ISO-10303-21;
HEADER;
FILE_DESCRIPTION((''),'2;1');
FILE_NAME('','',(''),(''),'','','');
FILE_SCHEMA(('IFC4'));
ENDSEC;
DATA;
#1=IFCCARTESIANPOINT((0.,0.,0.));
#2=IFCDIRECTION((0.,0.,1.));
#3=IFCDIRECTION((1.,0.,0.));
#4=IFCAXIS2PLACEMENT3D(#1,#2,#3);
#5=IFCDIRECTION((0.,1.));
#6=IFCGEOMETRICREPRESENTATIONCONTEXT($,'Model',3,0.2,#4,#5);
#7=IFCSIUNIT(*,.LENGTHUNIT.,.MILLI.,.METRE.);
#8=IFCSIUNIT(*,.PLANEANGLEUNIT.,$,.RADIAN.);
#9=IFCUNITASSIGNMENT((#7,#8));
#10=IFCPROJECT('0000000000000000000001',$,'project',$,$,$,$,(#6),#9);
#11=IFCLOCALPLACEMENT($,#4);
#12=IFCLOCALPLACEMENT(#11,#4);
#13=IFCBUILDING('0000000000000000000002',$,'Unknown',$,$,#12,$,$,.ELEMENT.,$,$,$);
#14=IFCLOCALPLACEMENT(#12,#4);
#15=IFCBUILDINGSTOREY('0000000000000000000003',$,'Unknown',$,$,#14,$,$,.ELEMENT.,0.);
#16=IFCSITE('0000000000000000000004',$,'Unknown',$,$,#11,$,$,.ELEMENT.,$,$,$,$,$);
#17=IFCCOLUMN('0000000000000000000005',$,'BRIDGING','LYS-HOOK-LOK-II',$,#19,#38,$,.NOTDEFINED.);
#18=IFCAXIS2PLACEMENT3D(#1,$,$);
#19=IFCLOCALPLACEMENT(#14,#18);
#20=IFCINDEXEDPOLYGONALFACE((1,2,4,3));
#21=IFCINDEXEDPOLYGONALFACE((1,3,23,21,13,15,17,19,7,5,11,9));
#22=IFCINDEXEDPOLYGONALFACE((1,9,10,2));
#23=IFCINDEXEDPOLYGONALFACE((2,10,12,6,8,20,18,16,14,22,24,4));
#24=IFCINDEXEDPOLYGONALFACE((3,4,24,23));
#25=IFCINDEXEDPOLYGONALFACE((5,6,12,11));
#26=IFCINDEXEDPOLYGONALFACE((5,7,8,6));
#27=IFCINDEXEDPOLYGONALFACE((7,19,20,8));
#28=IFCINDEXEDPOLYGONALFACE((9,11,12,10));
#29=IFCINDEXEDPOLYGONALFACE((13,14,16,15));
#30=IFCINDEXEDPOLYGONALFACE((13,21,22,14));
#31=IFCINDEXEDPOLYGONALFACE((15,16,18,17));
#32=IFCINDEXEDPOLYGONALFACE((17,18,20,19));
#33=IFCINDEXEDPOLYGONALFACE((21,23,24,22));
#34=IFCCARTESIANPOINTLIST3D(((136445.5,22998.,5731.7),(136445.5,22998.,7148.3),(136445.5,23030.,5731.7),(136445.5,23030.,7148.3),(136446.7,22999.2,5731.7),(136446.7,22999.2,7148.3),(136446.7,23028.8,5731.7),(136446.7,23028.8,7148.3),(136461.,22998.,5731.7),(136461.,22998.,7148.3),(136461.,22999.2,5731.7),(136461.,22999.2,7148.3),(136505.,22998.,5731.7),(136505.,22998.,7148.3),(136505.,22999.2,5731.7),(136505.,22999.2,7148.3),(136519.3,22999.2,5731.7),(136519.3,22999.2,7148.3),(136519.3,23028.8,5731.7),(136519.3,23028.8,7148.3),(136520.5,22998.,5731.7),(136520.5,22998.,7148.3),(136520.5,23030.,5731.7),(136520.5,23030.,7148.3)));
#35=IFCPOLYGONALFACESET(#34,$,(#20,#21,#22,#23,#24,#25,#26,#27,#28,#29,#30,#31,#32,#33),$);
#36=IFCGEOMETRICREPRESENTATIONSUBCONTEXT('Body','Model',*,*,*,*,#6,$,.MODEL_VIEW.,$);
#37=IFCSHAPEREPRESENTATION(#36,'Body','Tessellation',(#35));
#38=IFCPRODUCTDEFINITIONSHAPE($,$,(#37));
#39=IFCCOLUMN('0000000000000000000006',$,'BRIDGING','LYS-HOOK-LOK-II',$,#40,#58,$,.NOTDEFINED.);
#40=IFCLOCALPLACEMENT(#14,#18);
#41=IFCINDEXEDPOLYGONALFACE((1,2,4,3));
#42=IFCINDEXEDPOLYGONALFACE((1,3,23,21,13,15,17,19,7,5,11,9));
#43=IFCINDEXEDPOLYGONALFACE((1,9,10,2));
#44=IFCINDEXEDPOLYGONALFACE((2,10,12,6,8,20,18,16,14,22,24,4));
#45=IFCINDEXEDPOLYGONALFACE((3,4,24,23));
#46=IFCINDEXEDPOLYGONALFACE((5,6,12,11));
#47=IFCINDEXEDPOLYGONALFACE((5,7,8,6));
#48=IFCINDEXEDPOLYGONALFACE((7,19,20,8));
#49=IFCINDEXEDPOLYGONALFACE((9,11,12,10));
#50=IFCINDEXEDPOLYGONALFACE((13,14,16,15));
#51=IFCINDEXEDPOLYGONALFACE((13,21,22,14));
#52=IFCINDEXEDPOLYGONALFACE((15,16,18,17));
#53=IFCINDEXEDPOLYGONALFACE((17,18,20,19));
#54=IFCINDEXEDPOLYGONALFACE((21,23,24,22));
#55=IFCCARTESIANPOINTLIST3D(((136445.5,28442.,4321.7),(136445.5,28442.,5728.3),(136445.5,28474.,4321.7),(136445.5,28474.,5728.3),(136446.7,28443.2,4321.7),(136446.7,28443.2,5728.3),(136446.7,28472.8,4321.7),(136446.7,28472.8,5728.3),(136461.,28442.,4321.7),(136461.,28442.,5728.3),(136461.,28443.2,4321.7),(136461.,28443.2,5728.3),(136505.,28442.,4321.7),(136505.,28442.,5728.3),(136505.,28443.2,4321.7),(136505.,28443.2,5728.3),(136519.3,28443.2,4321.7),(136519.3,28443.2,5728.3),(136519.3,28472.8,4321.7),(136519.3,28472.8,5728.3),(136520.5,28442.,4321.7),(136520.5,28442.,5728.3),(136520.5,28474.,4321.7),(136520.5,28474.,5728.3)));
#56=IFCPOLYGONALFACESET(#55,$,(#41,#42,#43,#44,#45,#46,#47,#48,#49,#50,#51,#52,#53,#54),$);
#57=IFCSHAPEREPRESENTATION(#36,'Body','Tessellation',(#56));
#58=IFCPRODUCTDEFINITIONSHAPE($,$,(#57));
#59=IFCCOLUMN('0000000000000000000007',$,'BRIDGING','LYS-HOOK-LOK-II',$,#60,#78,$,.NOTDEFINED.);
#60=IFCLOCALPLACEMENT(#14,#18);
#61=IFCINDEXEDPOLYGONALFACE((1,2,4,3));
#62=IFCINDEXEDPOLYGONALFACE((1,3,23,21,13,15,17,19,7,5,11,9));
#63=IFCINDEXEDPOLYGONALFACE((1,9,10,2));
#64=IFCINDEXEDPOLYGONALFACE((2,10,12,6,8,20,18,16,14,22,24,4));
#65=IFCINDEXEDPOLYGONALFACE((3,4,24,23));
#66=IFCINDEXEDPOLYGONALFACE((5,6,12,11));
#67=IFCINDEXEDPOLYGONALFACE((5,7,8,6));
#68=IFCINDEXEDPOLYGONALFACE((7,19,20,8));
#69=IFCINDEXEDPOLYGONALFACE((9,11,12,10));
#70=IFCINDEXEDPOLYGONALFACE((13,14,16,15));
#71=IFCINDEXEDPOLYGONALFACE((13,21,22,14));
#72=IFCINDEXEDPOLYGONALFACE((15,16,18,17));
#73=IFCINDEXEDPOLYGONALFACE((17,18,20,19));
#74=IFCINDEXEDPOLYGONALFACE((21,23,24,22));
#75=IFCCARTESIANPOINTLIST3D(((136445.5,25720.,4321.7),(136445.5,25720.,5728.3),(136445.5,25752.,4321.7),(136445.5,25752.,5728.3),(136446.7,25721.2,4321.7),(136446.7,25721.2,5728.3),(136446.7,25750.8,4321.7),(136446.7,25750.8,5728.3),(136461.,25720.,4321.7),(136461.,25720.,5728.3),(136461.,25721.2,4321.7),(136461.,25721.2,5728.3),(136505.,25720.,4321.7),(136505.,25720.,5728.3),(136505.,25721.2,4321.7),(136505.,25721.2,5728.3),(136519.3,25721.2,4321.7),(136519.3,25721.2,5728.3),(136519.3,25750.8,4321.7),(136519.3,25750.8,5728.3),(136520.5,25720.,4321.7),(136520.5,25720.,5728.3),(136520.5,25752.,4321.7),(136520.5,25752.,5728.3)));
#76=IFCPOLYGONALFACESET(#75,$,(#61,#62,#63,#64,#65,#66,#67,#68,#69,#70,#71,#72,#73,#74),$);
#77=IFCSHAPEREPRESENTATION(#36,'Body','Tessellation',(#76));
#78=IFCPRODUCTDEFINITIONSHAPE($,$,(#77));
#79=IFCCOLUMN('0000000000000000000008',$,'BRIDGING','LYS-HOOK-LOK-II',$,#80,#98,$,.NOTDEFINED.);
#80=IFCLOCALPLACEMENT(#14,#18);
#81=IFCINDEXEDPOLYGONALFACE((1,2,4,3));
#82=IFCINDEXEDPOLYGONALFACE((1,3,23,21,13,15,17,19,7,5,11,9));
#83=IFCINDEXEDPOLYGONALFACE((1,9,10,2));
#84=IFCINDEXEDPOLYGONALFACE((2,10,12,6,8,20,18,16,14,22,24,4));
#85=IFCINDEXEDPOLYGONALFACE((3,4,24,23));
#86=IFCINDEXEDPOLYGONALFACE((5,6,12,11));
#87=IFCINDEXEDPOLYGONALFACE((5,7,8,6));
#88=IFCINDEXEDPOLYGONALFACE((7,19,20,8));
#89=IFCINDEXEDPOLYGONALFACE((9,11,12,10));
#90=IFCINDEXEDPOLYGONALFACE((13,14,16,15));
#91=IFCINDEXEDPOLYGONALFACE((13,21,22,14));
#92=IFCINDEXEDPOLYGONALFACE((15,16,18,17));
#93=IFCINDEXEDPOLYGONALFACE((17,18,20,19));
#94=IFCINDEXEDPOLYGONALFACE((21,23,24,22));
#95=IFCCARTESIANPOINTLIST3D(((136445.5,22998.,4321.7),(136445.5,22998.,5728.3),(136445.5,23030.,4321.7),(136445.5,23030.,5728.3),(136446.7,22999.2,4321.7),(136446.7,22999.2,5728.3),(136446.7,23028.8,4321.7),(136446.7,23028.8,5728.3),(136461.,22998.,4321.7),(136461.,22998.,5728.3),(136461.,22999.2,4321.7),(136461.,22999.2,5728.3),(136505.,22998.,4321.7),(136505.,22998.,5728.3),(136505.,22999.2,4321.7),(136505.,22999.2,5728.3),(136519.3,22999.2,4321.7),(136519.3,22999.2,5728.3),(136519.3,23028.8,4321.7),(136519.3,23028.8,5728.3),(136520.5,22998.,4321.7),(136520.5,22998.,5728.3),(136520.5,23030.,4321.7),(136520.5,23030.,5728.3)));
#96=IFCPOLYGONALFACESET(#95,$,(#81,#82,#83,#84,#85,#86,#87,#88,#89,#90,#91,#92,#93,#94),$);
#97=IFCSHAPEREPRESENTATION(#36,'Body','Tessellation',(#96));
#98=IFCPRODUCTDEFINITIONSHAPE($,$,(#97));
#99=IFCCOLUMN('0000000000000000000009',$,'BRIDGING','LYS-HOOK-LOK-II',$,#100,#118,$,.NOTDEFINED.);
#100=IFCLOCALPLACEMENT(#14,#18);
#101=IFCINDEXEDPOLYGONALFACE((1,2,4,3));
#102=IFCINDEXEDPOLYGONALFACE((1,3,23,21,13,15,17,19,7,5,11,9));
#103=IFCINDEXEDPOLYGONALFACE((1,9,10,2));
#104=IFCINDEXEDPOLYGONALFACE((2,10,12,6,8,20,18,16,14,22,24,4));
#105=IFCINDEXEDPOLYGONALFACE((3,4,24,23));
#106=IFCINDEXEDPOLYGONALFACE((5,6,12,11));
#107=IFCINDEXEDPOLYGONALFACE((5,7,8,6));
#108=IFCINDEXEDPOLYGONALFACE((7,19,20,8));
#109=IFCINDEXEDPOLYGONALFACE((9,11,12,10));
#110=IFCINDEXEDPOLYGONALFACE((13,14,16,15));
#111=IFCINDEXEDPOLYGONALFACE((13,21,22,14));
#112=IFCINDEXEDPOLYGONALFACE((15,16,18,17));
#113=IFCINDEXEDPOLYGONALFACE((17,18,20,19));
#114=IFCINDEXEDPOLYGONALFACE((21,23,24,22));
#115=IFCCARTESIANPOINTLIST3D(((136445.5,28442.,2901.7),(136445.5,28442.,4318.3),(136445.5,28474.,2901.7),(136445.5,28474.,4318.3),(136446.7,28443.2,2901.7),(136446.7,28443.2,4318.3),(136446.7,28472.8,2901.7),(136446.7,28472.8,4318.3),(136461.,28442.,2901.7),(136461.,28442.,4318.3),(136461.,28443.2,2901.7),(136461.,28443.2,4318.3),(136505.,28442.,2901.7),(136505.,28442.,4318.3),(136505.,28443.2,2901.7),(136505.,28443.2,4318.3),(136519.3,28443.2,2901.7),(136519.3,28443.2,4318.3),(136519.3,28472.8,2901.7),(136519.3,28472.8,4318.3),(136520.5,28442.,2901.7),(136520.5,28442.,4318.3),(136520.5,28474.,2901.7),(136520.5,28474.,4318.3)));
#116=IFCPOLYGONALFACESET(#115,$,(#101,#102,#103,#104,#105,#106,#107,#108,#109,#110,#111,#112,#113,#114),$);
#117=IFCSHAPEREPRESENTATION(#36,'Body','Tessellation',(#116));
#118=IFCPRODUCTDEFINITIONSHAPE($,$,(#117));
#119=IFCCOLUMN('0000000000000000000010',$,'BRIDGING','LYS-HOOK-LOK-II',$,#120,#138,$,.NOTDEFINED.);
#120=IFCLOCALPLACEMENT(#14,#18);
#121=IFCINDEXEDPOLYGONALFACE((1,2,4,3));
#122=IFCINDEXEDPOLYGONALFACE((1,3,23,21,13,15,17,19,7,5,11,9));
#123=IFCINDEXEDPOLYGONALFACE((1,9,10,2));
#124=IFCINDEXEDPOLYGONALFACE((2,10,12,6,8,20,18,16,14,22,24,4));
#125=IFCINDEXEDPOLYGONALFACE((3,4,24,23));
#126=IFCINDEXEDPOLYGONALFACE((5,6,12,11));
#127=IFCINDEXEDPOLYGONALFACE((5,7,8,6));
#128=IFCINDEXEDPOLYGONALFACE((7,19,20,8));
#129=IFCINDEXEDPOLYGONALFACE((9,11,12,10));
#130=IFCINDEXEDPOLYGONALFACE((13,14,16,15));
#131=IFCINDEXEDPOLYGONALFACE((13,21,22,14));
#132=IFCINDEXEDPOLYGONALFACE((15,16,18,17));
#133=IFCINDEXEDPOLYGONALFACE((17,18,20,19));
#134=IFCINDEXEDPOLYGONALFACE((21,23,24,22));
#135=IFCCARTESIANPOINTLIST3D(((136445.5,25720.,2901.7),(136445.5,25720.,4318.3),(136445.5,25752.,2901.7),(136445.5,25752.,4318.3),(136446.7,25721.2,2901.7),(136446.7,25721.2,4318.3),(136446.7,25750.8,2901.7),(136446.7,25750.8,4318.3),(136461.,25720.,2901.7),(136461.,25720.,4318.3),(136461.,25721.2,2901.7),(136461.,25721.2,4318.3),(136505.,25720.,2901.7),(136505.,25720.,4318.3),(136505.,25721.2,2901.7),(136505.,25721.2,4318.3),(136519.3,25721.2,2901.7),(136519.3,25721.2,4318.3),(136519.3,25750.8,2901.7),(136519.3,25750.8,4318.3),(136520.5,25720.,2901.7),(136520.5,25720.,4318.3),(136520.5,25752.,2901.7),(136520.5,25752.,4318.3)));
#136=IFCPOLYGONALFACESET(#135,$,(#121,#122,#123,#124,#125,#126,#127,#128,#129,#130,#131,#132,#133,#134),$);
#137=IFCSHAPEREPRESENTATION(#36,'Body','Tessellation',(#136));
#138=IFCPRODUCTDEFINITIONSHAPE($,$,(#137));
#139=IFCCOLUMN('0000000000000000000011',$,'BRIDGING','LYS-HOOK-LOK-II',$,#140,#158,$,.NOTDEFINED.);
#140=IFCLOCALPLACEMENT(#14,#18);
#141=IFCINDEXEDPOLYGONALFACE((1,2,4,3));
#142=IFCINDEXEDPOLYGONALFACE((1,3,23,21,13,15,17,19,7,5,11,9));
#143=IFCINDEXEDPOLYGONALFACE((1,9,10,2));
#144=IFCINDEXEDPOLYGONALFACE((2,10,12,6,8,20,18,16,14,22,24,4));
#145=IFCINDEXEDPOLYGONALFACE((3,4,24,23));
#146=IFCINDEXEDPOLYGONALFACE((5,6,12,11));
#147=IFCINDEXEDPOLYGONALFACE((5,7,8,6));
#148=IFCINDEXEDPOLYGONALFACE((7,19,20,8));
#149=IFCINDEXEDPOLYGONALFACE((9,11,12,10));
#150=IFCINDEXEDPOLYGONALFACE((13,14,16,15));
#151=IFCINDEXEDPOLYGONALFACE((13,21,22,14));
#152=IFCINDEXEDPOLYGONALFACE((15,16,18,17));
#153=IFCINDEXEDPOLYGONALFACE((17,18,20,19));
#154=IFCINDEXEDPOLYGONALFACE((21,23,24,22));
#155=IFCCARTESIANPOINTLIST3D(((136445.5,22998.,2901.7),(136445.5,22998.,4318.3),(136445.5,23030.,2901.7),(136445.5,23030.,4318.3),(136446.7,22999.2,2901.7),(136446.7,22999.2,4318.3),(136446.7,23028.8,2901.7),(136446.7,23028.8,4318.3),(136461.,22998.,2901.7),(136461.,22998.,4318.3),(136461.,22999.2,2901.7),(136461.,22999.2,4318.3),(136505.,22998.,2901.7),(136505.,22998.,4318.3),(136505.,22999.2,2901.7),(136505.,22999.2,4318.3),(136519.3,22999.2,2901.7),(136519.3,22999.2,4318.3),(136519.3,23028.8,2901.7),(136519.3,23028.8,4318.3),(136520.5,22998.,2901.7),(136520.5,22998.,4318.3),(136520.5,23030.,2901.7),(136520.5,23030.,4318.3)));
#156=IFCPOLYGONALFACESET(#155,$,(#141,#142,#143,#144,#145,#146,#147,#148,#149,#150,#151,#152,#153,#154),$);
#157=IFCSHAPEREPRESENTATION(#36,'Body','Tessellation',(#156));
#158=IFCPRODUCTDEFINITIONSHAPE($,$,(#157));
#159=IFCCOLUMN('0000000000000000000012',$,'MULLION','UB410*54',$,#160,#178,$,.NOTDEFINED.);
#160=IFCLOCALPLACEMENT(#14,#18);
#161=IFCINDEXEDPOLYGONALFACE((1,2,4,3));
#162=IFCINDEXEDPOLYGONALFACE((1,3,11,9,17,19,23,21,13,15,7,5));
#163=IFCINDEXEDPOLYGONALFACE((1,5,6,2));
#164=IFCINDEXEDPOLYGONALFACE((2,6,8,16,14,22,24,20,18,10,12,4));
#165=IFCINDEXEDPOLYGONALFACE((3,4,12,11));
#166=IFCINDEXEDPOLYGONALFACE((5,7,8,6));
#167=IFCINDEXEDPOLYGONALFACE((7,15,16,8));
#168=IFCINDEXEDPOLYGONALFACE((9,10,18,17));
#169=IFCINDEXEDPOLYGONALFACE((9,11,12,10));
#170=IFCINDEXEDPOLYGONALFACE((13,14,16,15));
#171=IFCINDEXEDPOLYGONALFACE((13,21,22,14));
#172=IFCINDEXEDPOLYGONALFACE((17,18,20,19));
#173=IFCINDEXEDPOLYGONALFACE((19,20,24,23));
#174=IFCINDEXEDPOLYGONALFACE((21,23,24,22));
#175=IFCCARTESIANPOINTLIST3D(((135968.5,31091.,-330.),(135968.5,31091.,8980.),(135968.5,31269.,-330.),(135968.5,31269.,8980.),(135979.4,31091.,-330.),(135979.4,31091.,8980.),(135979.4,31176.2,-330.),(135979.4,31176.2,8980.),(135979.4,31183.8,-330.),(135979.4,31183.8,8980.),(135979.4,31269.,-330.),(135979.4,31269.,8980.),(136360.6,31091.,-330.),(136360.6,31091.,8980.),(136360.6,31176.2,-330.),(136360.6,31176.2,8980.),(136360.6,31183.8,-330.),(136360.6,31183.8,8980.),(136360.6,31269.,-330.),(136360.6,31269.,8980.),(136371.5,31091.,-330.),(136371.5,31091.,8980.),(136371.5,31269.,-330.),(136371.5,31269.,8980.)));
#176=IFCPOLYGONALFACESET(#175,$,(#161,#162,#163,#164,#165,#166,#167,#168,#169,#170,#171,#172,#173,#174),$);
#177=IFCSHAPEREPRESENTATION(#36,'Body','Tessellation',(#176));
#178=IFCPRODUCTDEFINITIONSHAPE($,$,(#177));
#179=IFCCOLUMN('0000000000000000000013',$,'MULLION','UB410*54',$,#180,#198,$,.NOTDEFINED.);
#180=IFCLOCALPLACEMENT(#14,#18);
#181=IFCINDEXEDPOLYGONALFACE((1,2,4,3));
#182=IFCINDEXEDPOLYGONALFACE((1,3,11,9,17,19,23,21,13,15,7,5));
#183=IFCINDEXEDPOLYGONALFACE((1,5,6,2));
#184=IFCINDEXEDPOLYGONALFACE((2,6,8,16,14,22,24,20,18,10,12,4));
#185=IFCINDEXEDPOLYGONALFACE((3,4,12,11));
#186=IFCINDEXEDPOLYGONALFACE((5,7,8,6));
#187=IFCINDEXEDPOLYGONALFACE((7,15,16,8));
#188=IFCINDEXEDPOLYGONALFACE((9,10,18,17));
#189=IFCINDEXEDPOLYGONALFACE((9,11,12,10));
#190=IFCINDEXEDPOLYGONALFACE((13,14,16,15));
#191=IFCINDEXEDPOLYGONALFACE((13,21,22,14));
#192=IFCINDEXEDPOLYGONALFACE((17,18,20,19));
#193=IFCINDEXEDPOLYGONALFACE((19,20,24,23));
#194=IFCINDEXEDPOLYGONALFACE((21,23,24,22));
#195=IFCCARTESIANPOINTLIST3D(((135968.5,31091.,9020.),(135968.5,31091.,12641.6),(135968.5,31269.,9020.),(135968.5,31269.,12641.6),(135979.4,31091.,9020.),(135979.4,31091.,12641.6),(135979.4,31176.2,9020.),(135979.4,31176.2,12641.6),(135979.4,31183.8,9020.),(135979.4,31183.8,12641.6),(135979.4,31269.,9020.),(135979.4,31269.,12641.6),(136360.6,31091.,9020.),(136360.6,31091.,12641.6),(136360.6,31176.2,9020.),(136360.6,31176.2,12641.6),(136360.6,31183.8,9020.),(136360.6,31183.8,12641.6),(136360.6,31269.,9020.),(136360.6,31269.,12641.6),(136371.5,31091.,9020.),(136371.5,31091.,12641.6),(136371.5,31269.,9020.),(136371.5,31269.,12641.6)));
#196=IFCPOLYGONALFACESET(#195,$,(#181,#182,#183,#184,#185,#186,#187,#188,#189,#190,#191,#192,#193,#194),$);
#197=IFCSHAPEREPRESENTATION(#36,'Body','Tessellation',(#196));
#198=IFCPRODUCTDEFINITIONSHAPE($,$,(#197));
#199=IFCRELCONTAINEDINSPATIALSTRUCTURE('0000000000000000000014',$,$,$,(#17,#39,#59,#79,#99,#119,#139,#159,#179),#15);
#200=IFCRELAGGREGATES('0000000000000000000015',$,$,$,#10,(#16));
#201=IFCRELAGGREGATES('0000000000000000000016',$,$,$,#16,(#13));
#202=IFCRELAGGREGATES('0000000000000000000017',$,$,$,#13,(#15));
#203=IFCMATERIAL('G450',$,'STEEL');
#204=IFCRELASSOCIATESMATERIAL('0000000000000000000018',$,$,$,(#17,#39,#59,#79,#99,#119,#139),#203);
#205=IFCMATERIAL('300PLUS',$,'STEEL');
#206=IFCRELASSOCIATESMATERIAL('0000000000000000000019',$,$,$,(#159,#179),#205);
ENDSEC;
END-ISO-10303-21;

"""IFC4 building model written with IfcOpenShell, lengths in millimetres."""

from ifc_helpers import new_model, si_unit, direction, frame, origin_with_axes, place, context, subcontext, project, spatial, line, indexed_curve, outline, extrude, material, element, save


model = new_model("IFC4")

# Units and contexts
model_context = context("Model", 3, precision=0.2, world=origin_with_axes(), true_north=direction((0.0, 1.0)))
body_context = subcontext(model_context, "Body", "Model", "MODEL_VIEW")
ifc_project = project(units=[si_unit("LENGTHUNIT", "METRE", prefix="MILLI"), si_unit("PLANEANGLEUNIT", "RADIAN")], contexts=[model_context])

# Site, building, storey
site_placement = place(None, origin_with_axes())
site = spatial("IfcSite", under=ifc_project, at=site_placement, Name="Unknown", CompositionType="ELEMENT")
building_placement = place(site_placement, origin_with_axes())
building = spatial("IfcBuilding", under=site, at=building_placement, Name="Unknown", CompositionType="ELEMENT")
storey_placement = place(building_placement, origin_with_axes())
storey = spatial("IfcBuildingStorey", under=building, at=storey_placement, Name="Unknown", CompositionType="ELEMENT", Elevation=0.0)

# Columns
ifc_material_1 = material(Name="G450", Category="STEEL")
for number, where, z_axis, x_axis, name in (
    (1, (136483.0, 23014.0, 5731.7), (0.0, -1.0, 0.0), (0.0, 0.0, 1.0), "BRIDGING"),
):
    element("IfcColumn", number, at=place(storey_placement, frame(where, z_axis=z_axis, x_axis=x_axis)), inside=storey, material=ifc_material_1, Name=name, Description="LYS-HOOK-LOK-II", PredefinedType="NOTDEFINED", context=body_context, shape_type="SolidModel", body=[
        extrude(outline(indexed_curve([(16.0, -37.5), (16.0, -22.0), (14.8, -22.0), (14.8, -36.3), (-14.8, -36.3), (-14.8, 36.3), (14.8, 36.3), (14.8, 22.0), (16.0, 22.0), (16.0, 37.5), (-16.0, 37.5), (-16.0, -37.5)], segments=[line(1, 2, 3, 4, 5, 6, 7, 8, 9, 10, 11, 12, 1)])), frame((0.0, 0.0, 0.0), z_axis=(-1.0, 0.0, 0.0), x_axis=(0.0, 0.0, 1.0)), (0.0, 0.0, -1.0), 1416.6),
    ])
for number, where, z_axis, x_axis, name in (
    (2, (136483.0, 28458.0, 4321.7), (0.0, -1.0, 0.0), (0.0, 0.0, 1.0), "BRIDGING"),
    (3, (136483.0, 25736.0, 4321.7), (0.0, -1.0, 0.0), (0.0, 0.0, 1.0), "BRIDGING"),
    (4, (136483.0, 23014.0, 4321.7), (0.0, -1.0, 0.0), (0.0, 0.0, 1.0), "BRIDGING"),
):
    element("IfcColumn", number, at=place(storey_placement, frame(where, z_axis=z_axis, x_axis=x_axis)), inside=storey, material=ifc_material_1, Name=name, Description="LYS-HOOK-LOK-II", PredefinedType="NOTDEFINED", context=body_context, shape_type="SolidModel", body=[
        extrude(outline(indexed_curve([(16.0, -37.5), (16.0, -22.0), (14.8, -22.0), (14.8, -36.3), (-14.8, -36.3), (-14.8, 36.3), (14.8, 36.3), (14.8, 22.0), (16.0, 22.0), (16.0, 37.5), (-16.0, 37.5), (-16.0, -37.5)], segments=[line(1, 2, 3, 4, 5, 6, 7, 8, 9, 10, 11, 12, 1)])), frame((0.0, 0.0, 0.0), z_axis=(-1.0, 0.0, 0.0), x_axis=(0.0, 0.0, 1.0)), (0.0, 0.0, -1.0), 1406.6),
    ])
for number, where, z_axis, x_axis, name in (
    (5, (136483.0, 28458.0, 2901.7), (0.0, -1.0, 0.0), (0.0, 0.0, 1.0), "BRIDGING"),
    (6, (136483.0, 25736.0, 2901.7), (0.0, -1.0, 0.0), (0.0, 0.0, 1.0), "BRIDGING"),
    (7, (136483.0, 23014.0, 2901.7), (0.0, -1.0, 0.0), (0.0, 0.0, 1.0), "BRIDGING"),
):
    element("IfcColumn", number, at=place(storey_placement, frame(where, z_axis=z_axis, x_axis=x_axis)), inside=storey, material=ifc_material_1, Name=name, Description="LYS-HOOK-LOK-II", PredefinedType="NOTDEFINED", context=body_context, shape_type="SolidModel", body=[
        extrude(outline(indexed_curve([(16.0, -37.5), (16.0, -22.0), (14.8, -22.0), (14.8, -36.3), (-14.8, -36.3), (-14.8, 36.3), (14.8, 36.3), (14.8, 22.0), (16.0, 22.0), (16.0, 37.5), (-16.0, 37.5), (-16.0, -37.5)], segments=[line(1, 2, 3, 4, 5, 6, 7, 8, 9, 10, 11, 12, 1)])), frame((0.0, 0.0, 0.0), z_axis=(-1.0, 0.0, 0.0), x_axis=(0.0, 0.0, 1.0)), (0.0, 0.0, -1.0), 1416.6),
    ])
ifc_material_2 = material(Name="300PLUS", Category="STEEL")
column_1_placement = place(storey_placement, frame((136170.0, 31180.0, -330.0), z_axis=(0.0, -1.0, 0.0), x_axis=(0.0, 0.0, 1.0)))
element("IfcColumn", 8, at=column_1_placement, inside=storey, material=ifc_material_2, Name="MULLION", Description="UB410*54", PredefinedType="NOTDEFINED", context=body_context, shape_type="SolidModel", body=[
    extrude(outline(indexed_curve([(-89.0, -201.5), (89.0, -201.5), (89.0, -190.6), (3.8, -190.6), (3.8, 190.6), (89.0, 190.6), (89.0, 201.5), (-89.0, 201.5), (-89.0, 190.6), (-3.8, 190.6), (-3.8, -190.6), (-89.0, -190.6)], segments=[line(1, 2, 3, 4, 5, 6, 7, 8, 9, 10, 11, 12, 1)])), frame((0.0, 0.0, 0.0), z_axis=(-1.0, 0.0, 0.0), x_axis=(0.0, 0.0, 1.0)), (0.0, 0.0, -1.0), 9310.0),
])
column_2_placement = place(storey_placement, frame((136170.0, 31180.0, 9020.0), z_axis=(0.0, -1.0, 0.0), x_axis=(0.0, 0.0, 1.0)))
element("IfcColumn", 9, at=column_2_placement, inside=storey, material=ifc_material_2, Name="MULLION", Description="UB410*54", PredefinedType="NOTDEFINED", context=body_context, shape_type="SolidModel", body=[
    extrude(outline(indexed_curve([(-89.0, -201.5), (89.0, -201.5), (89.0, -190.6), (3.8, -190.6), (3.8, 190.6), (89.0, 190.6), (89.0, 201.5), (-89.0, 201.5), (-89.0, 190.6), (-3.8, 190.6), (-3.8, -190.6), (-89.0, -190.6)], segments=[line(1, 2, 3, 4, 5, 6, 7, 8, 9, 10, 11, 12, 1)])), frame((0.0, 0.0, 0.0), z_axis=(-1.0, 0.0, 0.0), x_axis=(0.0, 0.0, 1.0)), (0.0, 0.0, -1.0), 3621.6),
])

save(model, "model.ifc")
